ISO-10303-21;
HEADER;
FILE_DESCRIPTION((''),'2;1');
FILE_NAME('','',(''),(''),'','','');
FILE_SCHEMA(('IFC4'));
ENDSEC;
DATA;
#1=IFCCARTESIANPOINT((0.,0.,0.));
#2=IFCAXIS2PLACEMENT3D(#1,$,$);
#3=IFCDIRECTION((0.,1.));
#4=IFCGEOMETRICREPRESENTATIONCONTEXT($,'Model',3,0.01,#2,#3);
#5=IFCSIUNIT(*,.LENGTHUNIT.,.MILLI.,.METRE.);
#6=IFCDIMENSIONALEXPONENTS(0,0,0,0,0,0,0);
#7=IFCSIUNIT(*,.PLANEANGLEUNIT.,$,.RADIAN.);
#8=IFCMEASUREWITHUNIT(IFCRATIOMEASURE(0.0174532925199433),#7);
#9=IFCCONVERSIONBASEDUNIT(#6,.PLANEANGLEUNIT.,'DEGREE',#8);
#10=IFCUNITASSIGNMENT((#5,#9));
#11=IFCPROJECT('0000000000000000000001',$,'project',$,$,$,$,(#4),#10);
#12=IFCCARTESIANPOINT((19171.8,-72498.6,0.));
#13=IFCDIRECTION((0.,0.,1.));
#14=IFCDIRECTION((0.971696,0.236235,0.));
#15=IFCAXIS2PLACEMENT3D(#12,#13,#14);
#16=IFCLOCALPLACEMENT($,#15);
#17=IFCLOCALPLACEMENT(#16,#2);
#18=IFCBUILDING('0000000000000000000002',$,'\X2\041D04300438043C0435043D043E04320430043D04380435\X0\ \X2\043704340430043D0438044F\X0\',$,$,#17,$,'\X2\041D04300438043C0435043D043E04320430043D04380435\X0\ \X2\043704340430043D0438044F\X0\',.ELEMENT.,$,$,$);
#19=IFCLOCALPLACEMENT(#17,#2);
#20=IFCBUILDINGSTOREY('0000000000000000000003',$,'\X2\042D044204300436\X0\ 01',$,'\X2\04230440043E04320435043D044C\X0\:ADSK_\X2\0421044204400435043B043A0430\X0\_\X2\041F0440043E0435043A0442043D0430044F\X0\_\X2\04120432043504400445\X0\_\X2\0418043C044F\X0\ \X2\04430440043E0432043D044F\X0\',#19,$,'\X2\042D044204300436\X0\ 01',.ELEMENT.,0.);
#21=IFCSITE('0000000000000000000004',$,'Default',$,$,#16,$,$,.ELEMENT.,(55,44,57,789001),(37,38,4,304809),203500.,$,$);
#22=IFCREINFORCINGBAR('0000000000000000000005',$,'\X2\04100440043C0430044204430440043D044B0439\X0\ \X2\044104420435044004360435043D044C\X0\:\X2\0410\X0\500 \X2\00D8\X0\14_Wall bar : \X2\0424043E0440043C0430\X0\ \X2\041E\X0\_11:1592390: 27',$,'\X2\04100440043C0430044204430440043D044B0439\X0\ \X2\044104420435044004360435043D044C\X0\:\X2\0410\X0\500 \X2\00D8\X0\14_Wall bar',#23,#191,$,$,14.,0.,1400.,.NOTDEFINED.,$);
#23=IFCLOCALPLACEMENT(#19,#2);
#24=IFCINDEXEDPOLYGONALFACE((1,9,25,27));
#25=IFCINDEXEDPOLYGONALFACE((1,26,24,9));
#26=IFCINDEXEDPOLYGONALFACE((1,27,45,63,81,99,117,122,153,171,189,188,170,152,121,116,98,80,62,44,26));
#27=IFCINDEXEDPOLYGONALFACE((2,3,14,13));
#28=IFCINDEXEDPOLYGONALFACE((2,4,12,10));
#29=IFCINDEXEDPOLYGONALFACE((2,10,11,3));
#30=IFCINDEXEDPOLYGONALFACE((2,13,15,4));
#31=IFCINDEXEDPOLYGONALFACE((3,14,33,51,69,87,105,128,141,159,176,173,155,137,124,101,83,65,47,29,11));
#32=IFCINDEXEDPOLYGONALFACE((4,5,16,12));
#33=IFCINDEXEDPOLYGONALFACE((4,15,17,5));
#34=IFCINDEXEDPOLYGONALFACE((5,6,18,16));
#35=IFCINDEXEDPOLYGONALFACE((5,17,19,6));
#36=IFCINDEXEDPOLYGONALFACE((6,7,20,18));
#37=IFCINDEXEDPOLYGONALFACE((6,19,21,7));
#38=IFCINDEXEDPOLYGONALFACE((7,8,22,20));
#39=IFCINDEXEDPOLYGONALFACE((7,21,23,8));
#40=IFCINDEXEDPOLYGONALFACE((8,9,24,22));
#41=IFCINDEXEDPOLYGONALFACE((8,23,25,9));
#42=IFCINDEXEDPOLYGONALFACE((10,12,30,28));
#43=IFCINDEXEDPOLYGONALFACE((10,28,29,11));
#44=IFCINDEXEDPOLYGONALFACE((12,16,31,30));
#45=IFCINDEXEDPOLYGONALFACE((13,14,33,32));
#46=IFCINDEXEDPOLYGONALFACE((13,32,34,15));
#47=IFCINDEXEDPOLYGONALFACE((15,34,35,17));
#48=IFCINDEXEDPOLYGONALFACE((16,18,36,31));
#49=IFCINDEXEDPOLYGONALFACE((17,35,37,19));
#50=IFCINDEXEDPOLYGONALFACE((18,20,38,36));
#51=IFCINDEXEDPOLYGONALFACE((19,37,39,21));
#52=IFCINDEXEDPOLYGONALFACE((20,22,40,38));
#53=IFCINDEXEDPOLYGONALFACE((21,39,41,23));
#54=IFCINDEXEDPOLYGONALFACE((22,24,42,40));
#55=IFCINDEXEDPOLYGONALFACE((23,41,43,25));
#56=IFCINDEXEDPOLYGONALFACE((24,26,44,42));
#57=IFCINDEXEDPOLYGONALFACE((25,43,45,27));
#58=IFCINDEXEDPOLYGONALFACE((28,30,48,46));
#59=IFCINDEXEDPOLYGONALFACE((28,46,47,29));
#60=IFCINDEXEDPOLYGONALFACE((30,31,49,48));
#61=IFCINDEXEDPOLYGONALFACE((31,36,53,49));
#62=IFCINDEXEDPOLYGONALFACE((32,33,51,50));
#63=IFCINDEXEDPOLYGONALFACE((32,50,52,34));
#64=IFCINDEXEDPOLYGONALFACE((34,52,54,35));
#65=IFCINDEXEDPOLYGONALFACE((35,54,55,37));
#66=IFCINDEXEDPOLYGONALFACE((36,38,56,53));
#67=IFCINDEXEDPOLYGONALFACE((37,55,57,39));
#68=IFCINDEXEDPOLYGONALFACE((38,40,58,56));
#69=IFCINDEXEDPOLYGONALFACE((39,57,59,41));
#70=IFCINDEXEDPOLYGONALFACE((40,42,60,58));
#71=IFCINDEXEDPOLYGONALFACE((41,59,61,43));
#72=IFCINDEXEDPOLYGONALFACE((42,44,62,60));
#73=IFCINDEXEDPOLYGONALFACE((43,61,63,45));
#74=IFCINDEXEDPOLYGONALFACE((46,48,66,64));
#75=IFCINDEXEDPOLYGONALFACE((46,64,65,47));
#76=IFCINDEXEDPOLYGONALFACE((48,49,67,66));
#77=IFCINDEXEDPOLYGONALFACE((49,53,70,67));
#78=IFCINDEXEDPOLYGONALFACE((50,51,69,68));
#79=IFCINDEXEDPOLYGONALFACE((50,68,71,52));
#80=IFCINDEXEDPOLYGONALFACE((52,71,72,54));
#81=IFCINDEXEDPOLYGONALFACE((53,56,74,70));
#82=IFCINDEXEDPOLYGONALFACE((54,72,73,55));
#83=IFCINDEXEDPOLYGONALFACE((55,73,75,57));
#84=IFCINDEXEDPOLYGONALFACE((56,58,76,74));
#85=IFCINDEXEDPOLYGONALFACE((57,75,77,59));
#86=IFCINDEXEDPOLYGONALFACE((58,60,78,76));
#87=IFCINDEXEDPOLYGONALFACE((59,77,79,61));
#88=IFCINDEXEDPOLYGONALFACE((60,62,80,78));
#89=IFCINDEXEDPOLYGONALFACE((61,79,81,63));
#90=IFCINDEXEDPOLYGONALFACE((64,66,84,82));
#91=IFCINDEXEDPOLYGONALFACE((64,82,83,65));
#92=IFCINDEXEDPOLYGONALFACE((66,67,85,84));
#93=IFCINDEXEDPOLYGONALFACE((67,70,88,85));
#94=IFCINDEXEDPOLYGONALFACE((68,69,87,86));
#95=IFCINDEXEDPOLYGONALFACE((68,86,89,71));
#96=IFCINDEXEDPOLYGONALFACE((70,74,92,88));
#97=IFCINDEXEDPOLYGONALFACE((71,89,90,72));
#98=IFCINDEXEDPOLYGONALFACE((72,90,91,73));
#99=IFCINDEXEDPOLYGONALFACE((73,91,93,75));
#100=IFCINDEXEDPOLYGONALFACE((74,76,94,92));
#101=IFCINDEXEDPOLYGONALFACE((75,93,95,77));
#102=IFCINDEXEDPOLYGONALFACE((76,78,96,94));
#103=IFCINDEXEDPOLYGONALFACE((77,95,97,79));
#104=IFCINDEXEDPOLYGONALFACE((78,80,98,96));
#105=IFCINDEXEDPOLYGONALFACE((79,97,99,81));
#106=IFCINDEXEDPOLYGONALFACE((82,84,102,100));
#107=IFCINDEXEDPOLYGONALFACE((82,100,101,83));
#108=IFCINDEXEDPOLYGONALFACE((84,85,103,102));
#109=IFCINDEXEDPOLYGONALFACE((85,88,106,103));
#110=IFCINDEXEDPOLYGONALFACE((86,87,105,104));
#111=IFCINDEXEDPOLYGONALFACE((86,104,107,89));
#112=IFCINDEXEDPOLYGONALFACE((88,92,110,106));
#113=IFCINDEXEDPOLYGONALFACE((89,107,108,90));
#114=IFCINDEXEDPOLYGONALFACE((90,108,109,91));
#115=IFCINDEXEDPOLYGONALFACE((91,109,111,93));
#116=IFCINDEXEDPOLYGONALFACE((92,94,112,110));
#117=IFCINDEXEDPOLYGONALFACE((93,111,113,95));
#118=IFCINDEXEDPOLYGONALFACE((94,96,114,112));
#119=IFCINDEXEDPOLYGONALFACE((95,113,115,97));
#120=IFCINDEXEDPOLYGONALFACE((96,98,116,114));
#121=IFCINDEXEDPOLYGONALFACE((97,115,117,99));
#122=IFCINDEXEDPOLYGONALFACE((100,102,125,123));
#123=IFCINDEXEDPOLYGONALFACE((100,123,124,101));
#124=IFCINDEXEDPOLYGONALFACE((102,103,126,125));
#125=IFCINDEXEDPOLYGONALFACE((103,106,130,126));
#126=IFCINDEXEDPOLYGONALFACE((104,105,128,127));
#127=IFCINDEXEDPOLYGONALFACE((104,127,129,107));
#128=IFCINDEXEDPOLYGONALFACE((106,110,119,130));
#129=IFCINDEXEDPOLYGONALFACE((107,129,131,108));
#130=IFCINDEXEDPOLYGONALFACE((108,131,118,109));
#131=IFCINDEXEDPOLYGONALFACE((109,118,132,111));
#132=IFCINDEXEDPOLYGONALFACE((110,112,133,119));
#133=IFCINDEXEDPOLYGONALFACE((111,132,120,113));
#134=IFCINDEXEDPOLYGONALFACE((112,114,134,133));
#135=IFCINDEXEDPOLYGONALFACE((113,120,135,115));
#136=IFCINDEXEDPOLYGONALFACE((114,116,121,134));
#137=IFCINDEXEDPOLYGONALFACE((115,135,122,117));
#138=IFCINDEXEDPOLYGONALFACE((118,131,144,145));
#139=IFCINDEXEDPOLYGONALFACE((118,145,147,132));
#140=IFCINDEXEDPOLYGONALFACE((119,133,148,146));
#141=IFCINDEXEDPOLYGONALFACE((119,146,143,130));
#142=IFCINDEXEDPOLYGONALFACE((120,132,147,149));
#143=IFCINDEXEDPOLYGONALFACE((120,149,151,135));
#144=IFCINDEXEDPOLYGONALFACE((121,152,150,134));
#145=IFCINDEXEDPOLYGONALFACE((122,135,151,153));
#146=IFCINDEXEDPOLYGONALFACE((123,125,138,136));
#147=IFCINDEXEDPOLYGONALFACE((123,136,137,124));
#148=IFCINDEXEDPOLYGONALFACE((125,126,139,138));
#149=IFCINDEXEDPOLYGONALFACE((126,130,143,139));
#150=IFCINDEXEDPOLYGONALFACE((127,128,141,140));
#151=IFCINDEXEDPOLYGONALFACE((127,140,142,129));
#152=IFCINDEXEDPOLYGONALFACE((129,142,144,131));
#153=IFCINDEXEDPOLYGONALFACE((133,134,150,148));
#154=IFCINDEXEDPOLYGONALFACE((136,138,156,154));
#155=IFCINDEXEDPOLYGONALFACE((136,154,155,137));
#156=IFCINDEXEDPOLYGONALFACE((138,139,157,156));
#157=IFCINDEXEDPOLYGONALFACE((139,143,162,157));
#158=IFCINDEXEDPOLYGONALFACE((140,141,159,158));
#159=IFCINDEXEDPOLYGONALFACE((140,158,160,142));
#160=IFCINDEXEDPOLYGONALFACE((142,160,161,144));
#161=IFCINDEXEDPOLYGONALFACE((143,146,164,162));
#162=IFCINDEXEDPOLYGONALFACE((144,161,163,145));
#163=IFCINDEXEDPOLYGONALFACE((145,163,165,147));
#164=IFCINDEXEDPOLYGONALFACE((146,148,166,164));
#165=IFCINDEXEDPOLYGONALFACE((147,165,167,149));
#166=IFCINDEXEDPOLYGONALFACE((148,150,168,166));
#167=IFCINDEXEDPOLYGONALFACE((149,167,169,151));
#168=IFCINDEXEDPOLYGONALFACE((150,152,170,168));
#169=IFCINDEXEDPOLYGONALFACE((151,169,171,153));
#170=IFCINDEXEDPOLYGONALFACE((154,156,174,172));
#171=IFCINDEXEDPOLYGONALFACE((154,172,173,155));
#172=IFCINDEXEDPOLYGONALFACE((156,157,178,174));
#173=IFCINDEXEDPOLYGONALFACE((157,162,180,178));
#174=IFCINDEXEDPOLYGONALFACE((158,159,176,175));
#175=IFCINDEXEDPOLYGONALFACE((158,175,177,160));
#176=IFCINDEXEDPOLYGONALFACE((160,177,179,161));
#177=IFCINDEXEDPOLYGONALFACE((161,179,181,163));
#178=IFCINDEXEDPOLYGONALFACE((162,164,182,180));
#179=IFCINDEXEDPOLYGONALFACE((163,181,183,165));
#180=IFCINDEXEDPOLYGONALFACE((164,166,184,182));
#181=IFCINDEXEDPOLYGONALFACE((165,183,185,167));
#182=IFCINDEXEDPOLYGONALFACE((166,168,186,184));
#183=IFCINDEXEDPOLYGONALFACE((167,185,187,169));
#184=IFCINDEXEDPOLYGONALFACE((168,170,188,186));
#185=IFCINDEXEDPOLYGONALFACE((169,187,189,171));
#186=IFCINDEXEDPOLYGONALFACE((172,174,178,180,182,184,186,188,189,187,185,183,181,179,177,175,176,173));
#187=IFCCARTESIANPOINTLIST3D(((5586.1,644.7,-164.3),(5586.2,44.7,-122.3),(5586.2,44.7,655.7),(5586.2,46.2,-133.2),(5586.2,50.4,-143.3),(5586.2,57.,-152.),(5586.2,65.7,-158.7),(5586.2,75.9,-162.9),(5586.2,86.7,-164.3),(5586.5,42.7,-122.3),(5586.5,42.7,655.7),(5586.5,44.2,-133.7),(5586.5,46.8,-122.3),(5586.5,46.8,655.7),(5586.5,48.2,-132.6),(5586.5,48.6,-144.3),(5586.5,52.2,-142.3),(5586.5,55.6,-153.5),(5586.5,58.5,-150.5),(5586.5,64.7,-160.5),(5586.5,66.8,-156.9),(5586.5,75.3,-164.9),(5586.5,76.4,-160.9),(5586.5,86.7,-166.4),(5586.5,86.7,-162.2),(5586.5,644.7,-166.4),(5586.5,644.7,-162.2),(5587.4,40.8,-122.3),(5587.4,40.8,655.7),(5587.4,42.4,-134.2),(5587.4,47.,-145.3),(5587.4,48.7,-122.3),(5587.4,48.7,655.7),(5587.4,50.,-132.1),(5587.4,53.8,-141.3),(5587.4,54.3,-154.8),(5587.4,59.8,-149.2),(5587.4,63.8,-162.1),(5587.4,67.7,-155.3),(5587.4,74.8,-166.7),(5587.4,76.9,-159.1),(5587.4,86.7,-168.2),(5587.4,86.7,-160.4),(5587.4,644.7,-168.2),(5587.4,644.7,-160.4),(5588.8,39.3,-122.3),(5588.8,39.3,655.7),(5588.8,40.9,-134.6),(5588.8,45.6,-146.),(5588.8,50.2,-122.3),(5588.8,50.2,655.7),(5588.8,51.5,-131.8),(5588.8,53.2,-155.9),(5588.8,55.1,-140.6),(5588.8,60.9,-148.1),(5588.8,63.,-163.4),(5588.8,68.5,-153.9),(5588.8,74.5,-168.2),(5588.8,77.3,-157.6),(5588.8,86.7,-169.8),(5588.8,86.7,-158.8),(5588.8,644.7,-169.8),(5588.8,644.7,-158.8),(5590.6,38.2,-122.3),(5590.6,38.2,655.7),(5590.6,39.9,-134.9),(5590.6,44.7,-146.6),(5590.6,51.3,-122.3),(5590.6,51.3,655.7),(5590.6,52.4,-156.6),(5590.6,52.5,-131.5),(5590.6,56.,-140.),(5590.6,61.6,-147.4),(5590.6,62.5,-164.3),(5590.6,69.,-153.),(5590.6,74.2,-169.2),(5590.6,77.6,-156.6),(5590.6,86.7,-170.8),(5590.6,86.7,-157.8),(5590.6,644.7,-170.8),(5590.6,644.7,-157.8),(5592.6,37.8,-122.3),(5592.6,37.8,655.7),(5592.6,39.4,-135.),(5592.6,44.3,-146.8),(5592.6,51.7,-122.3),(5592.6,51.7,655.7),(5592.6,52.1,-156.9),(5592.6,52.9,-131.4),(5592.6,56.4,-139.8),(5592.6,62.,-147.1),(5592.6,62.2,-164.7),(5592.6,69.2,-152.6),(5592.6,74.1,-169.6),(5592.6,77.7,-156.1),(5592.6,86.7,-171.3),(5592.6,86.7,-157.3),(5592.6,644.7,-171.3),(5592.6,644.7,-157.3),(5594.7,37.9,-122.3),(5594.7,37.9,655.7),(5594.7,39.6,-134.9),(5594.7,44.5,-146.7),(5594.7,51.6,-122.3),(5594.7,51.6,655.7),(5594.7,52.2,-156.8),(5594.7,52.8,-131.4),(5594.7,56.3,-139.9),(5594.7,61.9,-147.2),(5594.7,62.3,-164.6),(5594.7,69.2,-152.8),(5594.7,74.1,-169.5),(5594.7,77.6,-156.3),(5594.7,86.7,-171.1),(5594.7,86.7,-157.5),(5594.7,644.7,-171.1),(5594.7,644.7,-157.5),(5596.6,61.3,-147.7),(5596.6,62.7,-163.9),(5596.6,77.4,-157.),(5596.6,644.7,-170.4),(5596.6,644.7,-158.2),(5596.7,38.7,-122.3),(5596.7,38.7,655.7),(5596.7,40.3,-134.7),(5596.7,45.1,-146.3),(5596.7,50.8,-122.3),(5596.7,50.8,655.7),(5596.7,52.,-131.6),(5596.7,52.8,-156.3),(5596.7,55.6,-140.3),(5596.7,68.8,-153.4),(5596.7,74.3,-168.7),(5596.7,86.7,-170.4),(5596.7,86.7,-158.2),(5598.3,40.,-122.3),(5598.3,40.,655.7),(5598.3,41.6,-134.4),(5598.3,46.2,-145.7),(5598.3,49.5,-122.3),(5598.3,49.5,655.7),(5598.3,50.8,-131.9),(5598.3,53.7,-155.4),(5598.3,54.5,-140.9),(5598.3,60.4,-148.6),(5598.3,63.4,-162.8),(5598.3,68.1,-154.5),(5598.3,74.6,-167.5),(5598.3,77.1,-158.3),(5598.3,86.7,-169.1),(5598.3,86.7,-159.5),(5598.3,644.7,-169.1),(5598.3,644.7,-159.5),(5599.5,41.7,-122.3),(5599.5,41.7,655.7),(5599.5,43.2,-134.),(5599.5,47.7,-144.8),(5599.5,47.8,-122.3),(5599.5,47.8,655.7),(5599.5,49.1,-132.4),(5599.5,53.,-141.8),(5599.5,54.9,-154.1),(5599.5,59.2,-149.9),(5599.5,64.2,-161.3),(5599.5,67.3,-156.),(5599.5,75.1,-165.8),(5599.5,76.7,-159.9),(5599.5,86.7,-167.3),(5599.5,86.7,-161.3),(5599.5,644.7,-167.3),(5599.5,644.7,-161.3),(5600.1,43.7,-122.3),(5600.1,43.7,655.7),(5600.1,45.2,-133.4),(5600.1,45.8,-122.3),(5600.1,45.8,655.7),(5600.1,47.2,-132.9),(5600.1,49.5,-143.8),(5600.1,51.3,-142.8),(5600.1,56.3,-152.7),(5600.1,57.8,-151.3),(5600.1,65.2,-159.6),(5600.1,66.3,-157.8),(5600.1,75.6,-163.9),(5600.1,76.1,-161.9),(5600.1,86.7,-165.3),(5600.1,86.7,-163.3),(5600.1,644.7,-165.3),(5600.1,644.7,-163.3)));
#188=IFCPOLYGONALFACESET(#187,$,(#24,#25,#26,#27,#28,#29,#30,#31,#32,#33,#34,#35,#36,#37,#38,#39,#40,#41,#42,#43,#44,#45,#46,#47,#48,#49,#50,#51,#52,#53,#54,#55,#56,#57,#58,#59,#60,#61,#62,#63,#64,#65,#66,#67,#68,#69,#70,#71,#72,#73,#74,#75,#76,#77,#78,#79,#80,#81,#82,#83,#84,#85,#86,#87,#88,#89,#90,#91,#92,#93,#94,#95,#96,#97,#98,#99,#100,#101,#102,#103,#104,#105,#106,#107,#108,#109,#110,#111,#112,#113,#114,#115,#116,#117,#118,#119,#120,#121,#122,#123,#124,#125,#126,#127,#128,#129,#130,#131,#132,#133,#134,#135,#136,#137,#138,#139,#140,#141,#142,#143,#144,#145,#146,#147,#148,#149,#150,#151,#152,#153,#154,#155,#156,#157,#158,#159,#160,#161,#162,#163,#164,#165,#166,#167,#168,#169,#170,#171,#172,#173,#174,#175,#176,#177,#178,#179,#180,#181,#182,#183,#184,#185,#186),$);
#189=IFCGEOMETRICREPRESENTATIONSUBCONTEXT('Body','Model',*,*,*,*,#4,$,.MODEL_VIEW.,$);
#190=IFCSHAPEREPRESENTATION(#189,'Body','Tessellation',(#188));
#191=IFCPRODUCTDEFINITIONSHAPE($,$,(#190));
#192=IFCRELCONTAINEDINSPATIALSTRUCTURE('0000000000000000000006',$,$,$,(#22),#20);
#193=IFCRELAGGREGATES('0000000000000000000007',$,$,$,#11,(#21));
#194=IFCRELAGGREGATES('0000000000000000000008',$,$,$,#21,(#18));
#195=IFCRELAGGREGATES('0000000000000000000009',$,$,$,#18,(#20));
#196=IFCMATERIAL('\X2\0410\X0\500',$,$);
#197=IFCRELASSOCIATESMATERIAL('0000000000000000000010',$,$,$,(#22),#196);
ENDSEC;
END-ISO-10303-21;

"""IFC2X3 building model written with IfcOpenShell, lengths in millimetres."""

from ifc_helpers import new_model, entity, si_unit, converted_unit, direction, frame, origin, place, context, subcontext, project, spatial, material, element, save


model = new_model("IFC2X3")

# Units and contexts
model_context = context("Model", 3, precision=0.01, world=origin(), true_north=direction((0.0, 1.0)))
body_context = subcontext(model_context, "Body", "Model", "MODEL_VIEW")
ifc_project = project(units=[si_unit("LENGTHUNIT", "METRE", prefix="MILLI"), converted_unit("PLANEANGLEUNIT", "DEGREE", entity("IfcRatioMeasure", 0.0174532925199433), si_unit("PLANEANGLEUNIT", "RADIAN"), dimensions=[0, 0, 0, 0, 0, 0, 0])], contexts=[model_context])

# Site, building, storey
site_placement = place(None, frame((19171.8, -72498.6, 0.0), z_axis=(0.0, 0.0, 1.0), x_axis=(0.971696, 0.236235, 0.0)))
site = spatial("IfcSite", under=ifc_project, at=site_placement, Name="Default", CompositionType="ELEMENT", RefLatitude=(55, 44, 57, 789001), RefLongitude=(37, 38, 4, 304809), RefElevation=203500.0)
building_placement = place(site_placement, origin())
building = spatial("IfcBuilding", under=site, at=building_placement, Name="Наименование здания", LongName="Наименование здания", CompositionType="ELEMENT")
storey_placement = place(building_placement, origin())
storey = spatial("IfcBuildingStorey", under=building, at=storey_placement, Name="Этаж 01", ObjectType="Уровень:ADSK_Стрелка_Проектная_Вверх_Имя уровня", LongName="Этаж 01", CompositionType="ELEMENT", Elevation=0.0)

# Reinforcing bar
ifc_material = material(Name="А500")
placement = place(storey_placement, origin())
element("IfcReinforcingBar", 1, at=placement, inside=storey, material=ifc_material, Name="Арматурный стержень:А500 Ø14_Wall bar : Форма О_11:1592390: 27", ObjectType="Арматурный стержень:А500 Ø14_Wall bar", BarLength=1400.0, BarRole="NOTDEFINED", CrossSectionArea=0.0, NominalDiameter=14.0, context=body_context, shape_type="AdvancedSweptSolid", body=[
    entity("IfcSweptDiskSolid", entity("IfcCompositeCurve", [entity("IfcCompositeCurveSegment", "CONTINUOUS", True, entity("IfcPolyline", [entity("IfcCartesianPoint", [5593.1, 44.7, 655.7]), entity("IfcCartesianPoint", [5593.1, 44.7, -122.3])])), entity("IfcCompositeCurveSegment", "CONTINUOUS", True, entity("IfcTrimmedCurve", entity("IfcCircle", entity("IfcAxis2Placement3D", entity("IfcCartesianPoint", [5593.1, 86.7, -122.3]), entity("IfcDirection", [1.0, 0.0, 0.0]), entity("IfcDirection", [0.0, 0.0, -1.0])), 42.0), [entity("IfcParameterValue", 270.0)], [entity("IfcParameterValue", 360.0)], True, "PARAMETER")), entity("IfcCompositeCurveSegment", "CONTINUOUS", True, entity("IfcPolyline", [entity("IfcCartesianPoint", [5593.1, 86.7, -164.3]), entity("IfcCartesianPoint", [5593.1, 644.7, -164.3])]))], False), 7.0, None, 0.0, 92.0),
])

save(model, "model.ifc")
